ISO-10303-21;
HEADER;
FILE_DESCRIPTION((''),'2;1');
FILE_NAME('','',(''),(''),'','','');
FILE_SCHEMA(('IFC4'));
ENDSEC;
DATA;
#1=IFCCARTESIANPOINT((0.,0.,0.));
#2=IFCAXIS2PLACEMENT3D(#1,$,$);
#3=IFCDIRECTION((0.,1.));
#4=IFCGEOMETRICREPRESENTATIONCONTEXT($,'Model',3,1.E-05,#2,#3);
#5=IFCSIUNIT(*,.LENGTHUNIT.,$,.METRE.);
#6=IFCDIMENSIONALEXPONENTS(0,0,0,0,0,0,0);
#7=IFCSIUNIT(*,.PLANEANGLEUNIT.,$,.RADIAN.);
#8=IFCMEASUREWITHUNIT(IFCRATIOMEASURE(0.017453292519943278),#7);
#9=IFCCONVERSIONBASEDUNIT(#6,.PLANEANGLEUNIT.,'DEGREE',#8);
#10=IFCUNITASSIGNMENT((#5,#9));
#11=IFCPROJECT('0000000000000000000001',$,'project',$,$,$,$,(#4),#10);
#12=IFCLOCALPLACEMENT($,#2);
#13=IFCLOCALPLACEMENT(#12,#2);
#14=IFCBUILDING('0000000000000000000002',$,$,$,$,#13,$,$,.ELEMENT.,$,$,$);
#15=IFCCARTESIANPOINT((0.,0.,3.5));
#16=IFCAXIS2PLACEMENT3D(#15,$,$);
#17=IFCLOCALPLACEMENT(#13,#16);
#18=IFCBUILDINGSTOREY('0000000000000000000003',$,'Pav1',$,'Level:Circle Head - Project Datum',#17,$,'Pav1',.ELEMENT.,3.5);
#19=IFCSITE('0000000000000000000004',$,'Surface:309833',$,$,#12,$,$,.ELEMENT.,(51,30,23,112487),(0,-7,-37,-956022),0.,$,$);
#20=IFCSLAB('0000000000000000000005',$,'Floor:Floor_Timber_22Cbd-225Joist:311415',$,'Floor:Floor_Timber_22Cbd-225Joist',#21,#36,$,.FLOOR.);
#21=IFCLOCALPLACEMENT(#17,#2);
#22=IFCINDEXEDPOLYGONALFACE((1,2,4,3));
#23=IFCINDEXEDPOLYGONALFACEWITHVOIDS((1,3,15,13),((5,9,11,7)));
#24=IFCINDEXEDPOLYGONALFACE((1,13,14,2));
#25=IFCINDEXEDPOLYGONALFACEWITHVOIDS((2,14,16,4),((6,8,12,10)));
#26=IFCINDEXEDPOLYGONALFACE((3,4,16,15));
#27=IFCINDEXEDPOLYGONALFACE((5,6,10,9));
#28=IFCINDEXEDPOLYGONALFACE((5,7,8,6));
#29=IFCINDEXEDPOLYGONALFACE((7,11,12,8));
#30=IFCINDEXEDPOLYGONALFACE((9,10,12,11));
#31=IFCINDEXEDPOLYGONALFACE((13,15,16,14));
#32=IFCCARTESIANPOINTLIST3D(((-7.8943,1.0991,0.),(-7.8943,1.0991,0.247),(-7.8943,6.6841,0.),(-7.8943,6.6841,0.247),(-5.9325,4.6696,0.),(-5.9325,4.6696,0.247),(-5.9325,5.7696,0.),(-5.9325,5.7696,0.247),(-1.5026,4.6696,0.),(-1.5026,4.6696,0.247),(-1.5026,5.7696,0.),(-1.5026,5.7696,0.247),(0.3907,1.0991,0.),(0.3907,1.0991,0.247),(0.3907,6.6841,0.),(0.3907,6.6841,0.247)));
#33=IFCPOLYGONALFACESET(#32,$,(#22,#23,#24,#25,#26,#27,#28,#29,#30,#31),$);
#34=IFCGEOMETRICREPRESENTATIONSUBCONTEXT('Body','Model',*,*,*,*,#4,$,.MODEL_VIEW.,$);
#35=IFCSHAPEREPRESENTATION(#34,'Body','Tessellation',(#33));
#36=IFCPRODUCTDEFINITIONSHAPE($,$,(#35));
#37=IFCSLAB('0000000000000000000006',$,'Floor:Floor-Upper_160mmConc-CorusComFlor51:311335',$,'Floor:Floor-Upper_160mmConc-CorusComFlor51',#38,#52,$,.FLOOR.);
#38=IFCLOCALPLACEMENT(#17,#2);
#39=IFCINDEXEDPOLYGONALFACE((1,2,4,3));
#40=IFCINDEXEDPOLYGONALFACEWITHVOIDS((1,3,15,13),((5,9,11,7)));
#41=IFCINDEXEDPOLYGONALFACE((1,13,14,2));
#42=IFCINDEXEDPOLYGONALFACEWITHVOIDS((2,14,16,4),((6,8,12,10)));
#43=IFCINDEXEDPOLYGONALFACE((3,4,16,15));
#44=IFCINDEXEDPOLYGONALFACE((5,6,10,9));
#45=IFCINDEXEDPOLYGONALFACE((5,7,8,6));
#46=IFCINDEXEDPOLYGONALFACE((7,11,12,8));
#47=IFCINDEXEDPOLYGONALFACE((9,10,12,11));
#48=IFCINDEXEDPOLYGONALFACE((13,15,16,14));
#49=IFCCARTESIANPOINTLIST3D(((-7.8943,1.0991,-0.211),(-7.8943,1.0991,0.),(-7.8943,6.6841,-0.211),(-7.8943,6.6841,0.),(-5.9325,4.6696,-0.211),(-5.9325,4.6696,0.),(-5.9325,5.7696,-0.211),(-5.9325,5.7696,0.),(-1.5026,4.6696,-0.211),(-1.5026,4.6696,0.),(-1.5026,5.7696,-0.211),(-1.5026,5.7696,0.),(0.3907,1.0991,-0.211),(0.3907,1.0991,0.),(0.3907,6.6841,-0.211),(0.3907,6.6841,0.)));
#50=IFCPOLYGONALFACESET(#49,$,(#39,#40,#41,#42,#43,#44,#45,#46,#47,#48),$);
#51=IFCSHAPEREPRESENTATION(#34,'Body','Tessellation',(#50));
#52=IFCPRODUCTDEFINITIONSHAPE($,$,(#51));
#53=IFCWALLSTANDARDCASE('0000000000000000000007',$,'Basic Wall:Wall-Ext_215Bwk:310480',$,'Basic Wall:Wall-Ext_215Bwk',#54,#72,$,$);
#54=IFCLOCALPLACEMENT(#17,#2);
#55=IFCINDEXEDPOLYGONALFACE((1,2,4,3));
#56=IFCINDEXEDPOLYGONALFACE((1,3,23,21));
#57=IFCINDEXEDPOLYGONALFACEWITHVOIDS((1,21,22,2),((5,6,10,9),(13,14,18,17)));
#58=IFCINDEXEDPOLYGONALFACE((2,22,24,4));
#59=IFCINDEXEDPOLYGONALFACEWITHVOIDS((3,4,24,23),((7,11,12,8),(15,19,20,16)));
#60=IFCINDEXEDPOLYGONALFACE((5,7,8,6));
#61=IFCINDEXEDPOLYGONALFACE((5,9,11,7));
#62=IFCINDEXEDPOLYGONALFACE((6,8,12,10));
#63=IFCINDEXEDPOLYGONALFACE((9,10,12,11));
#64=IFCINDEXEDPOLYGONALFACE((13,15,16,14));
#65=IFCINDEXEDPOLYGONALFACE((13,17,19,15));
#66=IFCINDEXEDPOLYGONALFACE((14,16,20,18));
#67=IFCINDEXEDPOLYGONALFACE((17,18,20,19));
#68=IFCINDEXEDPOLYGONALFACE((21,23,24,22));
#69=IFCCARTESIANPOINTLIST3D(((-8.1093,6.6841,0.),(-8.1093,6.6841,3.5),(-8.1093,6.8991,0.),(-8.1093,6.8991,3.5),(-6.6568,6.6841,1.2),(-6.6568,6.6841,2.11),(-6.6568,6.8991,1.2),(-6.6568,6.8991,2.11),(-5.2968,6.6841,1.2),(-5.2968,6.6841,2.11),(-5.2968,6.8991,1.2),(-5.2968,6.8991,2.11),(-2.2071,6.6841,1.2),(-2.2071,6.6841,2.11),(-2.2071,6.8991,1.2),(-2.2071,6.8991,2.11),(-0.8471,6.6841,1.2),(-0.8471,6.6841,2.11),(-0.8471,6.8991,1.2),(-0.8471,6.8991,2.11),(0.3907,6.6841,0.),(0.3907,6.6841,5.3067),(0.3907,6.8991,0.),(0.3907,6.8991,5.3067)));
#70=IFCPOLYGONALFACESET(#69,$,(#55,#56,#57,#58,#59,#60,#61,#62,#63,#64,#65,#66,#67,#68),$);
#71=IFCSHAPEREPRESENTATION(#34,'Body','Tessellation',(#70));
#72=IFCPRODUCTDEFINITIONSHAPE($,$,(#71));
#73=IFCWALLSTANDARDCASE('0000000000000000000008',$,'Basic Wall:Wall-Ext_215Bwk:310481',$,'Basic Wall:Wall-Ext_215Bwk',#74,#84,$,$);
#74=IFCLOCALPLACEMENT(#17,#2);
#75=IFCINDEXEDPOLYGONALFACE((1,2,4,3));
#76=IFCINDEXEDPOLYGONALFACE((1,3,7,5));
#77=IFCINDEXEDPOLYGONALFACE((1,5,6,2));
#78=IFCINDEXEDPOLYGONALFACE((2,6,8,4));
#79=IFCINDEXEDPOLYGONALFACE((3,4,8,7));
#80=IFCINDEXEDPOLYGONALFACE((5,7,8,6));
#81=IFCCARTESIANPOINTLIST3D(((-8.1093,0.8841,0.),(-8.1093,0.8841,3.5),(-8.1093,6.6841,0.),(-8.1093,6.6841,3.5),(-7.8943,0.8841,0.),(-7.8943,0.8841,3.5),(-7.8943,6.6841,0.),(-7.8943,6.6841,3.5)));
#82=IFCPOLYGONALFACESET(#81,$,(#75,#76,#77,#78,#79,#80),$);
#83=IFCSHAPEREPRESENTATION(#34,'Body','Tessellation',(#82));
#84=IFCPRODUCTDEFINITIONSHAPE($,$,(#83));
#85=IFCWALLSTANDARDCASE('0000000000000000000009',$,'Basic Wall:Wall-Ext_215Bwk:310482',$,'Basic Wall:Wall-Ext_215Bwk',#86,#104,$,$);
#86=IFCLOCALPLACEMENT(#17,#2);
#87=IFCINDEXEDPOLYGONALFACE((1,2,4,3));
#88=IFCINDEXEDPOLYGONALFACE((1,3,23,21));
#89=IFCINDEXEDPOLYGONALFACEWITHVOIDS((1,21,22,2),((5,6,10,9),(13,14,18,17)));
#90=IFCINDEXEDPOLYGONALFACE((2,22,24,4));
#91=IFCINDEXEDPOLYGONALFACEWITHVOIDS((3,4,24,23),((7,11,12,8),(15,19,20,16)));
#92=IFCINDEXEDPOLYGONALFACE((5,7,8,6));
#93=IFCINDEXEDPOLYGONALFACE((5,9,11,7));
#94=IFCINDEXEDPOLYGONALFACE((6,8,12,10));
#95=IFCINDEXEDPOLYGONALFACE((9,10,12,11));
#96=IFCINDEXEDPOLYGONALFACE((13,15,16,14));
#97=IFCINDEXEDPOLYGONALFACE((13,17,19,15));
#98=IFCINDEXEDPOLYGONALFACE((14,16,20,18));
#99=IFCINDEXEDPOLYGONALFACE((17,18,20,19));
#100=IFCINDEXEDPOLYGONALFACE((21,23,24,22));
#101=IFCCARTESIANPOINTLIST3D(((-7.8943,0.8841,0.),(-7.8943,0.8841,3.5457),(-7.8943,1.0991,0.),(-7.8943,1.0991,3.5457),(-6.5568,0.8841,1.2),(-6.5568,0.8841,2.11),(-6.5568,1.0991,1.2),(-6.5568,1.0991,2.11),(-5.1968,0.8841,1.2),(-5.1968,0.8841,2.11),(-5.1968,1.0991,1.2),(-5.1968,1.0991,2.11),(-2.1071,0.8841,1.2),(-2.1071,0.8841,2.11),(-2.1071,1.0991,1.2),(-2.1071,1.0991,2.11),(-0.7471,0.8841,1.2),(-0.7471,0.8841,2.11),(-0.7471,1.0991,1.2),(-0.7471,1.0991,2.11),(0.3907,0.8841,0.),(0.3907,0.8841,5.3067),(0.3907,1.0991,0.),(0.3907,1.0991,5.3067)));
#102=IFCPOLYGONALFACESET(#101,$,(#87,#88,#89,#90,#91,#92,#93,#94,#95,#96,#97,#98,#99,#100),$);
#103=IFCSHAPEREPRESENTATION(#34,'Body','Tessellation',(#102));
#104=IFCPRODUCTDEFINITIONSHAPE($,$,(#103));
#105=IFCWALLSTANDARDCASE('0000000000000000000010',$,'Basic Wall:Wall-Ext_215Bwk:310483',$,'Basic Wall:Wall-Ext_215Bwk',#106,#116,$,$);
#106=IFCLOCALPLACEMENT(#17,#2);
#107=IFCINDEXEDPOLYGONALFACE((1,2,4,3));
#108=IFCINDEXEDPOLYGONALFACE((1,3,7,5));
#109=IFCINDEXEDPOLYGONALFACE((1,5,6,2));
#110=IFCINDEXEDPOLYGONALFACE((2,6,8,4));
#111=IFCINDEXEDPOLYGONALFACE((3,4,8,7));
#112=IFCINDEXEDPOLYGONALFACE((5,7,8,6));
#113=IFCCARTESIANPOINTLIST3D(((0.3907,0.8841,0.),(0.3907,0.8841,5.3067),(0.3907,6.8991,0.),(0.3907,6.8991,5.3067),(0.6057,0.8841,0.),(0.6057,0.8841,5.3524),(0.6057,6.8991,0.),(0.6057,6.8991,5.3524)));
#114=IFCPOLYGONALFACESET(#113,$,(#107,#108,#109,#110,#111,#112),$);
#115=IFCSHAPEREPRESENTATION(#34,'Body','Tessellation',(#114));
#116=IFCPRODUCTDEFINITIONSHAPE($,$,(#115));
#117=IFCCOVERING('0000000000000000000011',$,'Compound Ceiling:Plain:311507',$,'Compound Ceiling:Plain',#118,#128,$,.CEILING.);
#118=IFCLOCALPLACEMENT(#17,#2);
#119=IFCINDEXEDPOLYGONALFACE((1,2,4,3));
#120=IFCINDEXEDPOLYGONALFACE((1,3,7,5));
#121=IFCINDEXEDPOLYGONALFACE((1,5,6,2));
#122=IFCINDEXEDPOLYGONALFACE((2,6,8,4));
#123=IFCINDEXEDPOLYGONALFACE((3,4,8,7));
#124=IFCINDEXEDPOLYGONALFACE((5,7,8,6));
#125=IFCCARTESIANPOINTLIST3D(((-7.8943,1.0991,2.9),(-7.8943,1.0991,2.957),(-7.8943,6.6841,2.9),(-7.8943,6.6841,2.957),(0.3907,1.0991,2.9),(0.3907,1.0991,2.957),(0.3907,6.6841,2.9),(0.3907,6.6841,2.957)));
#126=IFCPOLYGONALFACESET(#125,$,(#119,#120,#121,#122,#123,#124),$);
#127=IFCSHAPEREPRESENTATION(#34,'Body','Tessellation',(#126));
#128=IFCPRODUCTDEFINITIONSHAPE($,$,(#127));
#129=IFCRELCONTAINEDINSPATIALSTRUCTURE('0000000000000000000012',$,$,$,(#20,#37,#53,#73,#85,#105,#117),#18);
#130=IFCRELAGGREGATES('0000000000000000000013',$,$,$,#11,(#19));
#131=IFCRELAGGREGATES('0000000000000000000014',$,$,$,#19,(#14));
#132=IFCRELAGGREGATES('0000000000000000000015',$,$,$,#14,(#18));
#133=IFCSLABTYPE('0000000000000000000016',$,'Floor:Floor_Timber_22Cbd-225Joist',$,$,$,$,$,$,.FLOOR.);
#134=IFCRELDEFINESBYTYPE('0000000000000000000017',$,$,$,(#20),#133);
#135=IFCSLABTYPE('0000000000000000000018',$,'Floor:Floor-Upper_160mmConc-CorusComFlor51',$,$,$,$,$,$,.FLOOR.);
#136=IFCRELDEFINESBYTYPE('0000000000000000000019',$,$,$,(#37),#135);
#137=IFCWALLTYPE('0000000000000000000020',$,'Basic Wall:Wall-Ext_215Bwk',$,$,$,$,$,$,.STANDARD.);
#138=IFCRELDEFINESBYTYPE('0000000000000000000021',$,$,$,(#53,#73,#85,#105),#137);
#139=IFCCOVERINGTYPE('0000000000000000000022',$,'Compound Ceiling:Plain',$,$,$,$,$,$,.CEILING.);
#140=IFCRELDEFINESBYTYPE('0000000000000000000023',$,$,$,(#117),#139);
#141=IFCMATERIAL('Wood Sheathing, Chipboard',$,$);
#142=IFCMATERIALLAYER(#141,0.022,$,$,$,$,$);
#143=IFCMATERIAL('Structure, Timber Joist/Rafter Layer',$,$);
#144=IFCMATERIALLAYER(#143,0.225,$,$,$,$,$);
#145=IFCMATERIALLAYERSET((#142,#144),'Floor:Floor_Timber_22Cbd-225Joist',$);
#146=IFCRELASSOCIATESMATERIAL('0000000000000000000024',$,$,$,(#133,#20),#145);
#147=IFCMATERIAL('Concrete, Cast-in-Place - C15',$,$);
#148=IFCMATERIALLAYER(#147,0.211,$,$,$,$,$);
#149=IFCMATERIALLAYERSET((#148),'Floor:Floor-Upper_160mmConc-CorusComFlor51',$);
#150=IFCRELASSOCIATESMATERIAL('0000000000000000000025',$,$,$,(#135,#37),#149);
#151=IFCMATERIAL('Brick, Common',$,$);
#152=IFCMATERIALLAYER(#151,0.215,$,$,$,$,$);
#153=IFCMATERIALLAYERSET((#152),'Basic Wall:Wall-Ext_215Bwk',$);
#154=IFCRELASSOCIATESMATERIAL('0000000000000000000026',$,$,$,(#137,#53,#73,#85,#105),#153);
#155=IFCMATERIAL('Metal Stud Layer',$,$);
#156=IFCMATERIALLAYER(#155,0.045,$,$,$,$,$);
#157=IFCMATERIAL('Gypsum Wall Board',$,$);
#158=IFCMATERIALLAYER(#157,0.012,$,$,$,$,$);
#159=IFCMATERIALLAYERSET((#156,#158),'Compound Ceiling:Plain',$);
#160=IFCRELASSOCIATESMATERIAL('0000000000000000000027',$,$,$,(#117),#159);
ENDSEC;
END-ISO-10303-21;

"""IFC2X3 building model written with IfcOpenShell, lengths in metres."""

from ifc_helpers import new_model, entity, si_unit, converted_unit, direction, frame, frame_2d, origin, place, context, subcontext, project, spatial, polyline, rectangle, extrude, clip, bounded_halfspace, material, layer, layer_set, layer_usage, type_object, element, save


model = new_model("IFC2X3")

# Units and contexts
model_context = context("Model", 3, precision=1e-05, world=origin(), true_north=direction((0.0, 1.0)))
body_context = subcontext(model_context, "Body", "Model", "MODEL_VIEW")
ifc_project = project(units=[si_unit("LENGTHUNIT", "METRE"), converted_unit("PLANEANGLEUNIT", "DEGREE", entity("IfcRatioMeasure", 0.017453292519943278), si_unit("PLANEANGLEUNIT", "RADIAN"), dimensions=[0, 0, 0, 0, 0, 0, 0])], contexts=[model_context])

# Site, building, storey
site_placement = place(None, origin())
site = spatial("IfcSite", under=ifc_project, at=site_placement, Name="Surface:309833", CompositionType="ELEMENT", RefLatitude=(51, 30, 23, 112487), RefLongitude=(0, -7, -37, -956022), RefElevation=0.0)
building_placement = place(site_placement, origin())
building = spatial("IfcBuilding", under=site, at=building_placement, CompositionType="ELEMENT")
storey_placement = place(building_placement, frame((0.0, 0.0, 3.5)))
storey = spatial("IfcBuildingStorey", under=building, at=storey_placement, Name="Pav1", ObjectType="Level:Circle Head - Project Datum", LongName="Pav1", CompositionType="ELEMENT", Elevation=3.5)

# Slabs, openings
ifc_material_1 = material(Name="Wood Sheathing, Chipboard")
ifc_layer_1 = layer(ifc_material_1, 0.022)
ifc_material_2 = material(Name="Structure, Timber Joist/Rafter Layer")
ifc_layer_2 = layer(ifc_material_2, 0.225)
ifc_layer_set_1 = layer_set([ifc_layer_1, ifc_layer_2], Name="Floor:Floor_Timber_22Cbd-225Joist")
ifc_layer_usage_1 = layer_usage(ifc_layer_set_1, "AXIS3", "POSITIVE", 0.0)
slab_type_1 = type_object("IfcSlabType", Name="Floor:Floor_Timber_22Cbd-225Joist", PredefinedType="FLOOR", material=ifc_layer_set_1)
slab_1_placement = place(storey_placement, frame((-7.8943, 1.0991, 0.0)))
slab_1 = element("IfcSlab", 1, at=slab_1_placement, inside=storey, type_object=slab_type_1, material=ifc_layer_usage_1, Name="Floor:Floor_Timber_22Cbd-225Joist:311415", ObjectType="Floor:Floor_Timber_22Cbd-225Joist", PredefinedType="FLOOR", context=body_context, shape_type="SweptSolid", body=[
    extrude(rectangle(XDim=5.585, YDim=8.285, at=frame_2d((0.0, 0.0), x_axis=(0.0, -1.0))), frame((4.1425, 2.7925, 0.247), z_axis=(0.0, 0.0, -1.0), x_axis=(-1.0, 0.0, 0.0)), (0.0, 0.0, 1.0), 0.247),
])
opening_1_placement = place(slab_1_placement, origin())
element("IfcOpeningElement", 2, at=opening_1_placement, cuts=slab_1, ObjectType="Opening", context=body_context, shape_type="SweptSolid", body=[
    extrude(rectangle(XDim=4.4299, YDim=1.1, at=frame_2d((0.0, 0.0), x_axis=(1.0, 0.0))), frame((4.1768, 4.1206, 0.247), z_axis=(0.0, 0.0, -1.0), x_axis=(1.0, 0.0, 0.0)), (0.0, 0.0, 1.0), 0.247),
])
ifc_material_3 = material(Name="Concrete, Cast-in-Place - C15")
ifc_layer_3 = layer(ifc_material_3, 0.211)
ifc_layer_set_2 = layer_set([ifc_layer_3], Name="Floor:Floor-Upper_160mmConc-CorusComFlor51")
ifc_layer_usage_2 = layer_usage(ifc_layer_set_2, "AXIS3", "POSITIVE", 0.0)
slab_type_2 = type_object("IfcSlabType", Name="Floor:Floor-Upper_160mmConc-CorusComFlor51", PredefinedType="FLOOR", material=ifc_layer_set_2)
slab_2_placement = place(storey_placement, frame((-7.8943, 1.0991, -0.211)))
slab_2 = element("IfcSlab", 3, at=slab_2_placement, inside=storey, type_object=slab_type_2, material=ifc_layer_usage_2, Name="Floor:Floor-Upper_160mmConc-CorusComFlor51:311335", ObjectType="Floor:Floor-Upper_160mmConc-CorusComFlor51", PredefinedType="FLOOR", context=body_context, shape_type="SweptSolid", body=[
    extrude(rectangle(XDim=5.585, YDim=8.285, at=frame_2d((0.0, 0.0), x_axis=(0.0, -1.0))), frame((4.1425, 2.7925, 0.211), z_axis=(0.0, 0.0, -1.0), x_axis=(-1.0, 0.0, 0.0)), (0.0, 0.0, 1.0), 0.211),
])
opening_2_placement = place(slab_2_placement, origin())
element("IfcOpeningElement", 4, at=opening_2_placement, cuts=slab_2, ObjectType="Opening", context=body_context, shape_type="SweptSolid", body=[
    extrude(rectangle(XDim=1.1, YDim=4.4299, at=frame_2d((0.0, 0.0), x_axis=(1.0, 0.0))), frame((4.1768, 4.1206, 0.211), z_axis=(0.0, 0.0, -1.0), x_axis=(0.0, -1.0, 0.0)), (0.0, 0.0, 1.0), 0.211),
])

# Wall, openings
ifc_material_4 = material(Name="Brick, Common")
ifc_layer_4 = layer(ifc_material_4, 0.215)
ifc_layer_set_3 = layer_set([ifc_layer_4], Name="Basic Wall:Wall-Ext_215Bwk")
ifc_layer_usage_3 = layer_usage(ifc_layer_set_3, "AXIS2", "NEGATIVE", 0.1075)
wall_type = type_object("IfcWallType", Name="Basic Wall:Wall-Ext_215Bwk", PredefinedType="STANDARD", material=ifc_layer_set_3)
wall_1_placement = place(storey_placement, frame((-8.1093, 6.7916, 0.0)))
wall_1 = element("IfcWallStandardCase", 5, at=wall_1_placement, inside=storey, type_object=wall_type, material=ifc_layer_usage_3, Name="Basic Wall:Wall-Ext_215Bwk:310480", ObjectType="Basic Wall:Wall-Ext_215Bwk", context=body_context, shape_type="Clipping", body=[
    clip(extrude(rectangle(XDim=8.5, YDim=0.215, at=frame_2d((4.25, 0.0), x_axis=(-1.0, 0.0))), origin(), (0.0, 0.0, 1.0), 5.3067), bounded_halfspace(frame((0.0, -0.1075, 3.5), z_axis=(-0.207912, 0.0, 0.978148), x_axis=(0.0, -1.0, 0.0)), False, frame((0.0, -0.1075, 3.5)), polyline([(0.0, 0.0), (8.5, 0.0), (8.5, 0.215), (0.0, 0.215), (0.0, 0.0)]))),
])
opening_3_placement = place(wall_1_placement, frame((2.8125, 0.1075, 1.2)))
element("IfcOpeningElement", 6, at=opening_3_placement, cuts=wall_1, ObjectType="Opening", context=body_context, shape_type="SweptSolid", body=[
    extrude(rectangle(XDim=0.91, YDim=1.36, at=frame_2d((0.455, 0.68), x_axis=(-1.0, 0.0))), frame((0.0, 0.0, 0.0), z_axis=(0.0, -1.0, 0.0), x_axis=(0.0, 0.0, 1.0)), (0.0, 0.0, 1.0), 0.215),
])
opening_4_placement = place(wall_1_placement, frame((7.2622, 0.1075, 1.2)))
element("IfcOpeningElement", 7, at=opening_4_placement, cuts=wall_1, ObjectType="Opening", context=body_context, shape_type="SweptSolid", body=[
    extrude(rectangle(XDim=0.91, YDim=1.36, at=frame_2d((0.455, 0.68), x_axis=(-1.0, 0.0))), frame((0.0, 0.0, 0.0), z_axis=(0.0, -1.0, 0.0), x_axis=(0.0, 0.0, 1.0)), (0.0, 0.0, 1.0), 0.215),
])

# Wall
wall_2_placement = place(storey_placement, frame((-8.0018, 0.8841, 0.0), z_axis=(0.0, 0.0, 1.0), x_axis=(0.0, 1.0, 0.0)))
element("IfcWallStandardCase", 8, at=wall_2_placement, inside=storey, type_object=wall_type, material=ifc_layer_usage_3, Name="Basic Wall:Wall-Ext_215Bwk:310481", ObjectType="Basic Wall:Wall-Ext_215Bwk", context=body_context, shape_type="SweptSolid", body=[
    extrude(rectangle(XDim=5.8, YDim=0.215, at=frame_2d((2.9, 0.0), x_axis=(-1.0, 0.0))), origin(), (0.0, 0.0, 1.0), 3.5),
])

# Wall, openings
wall_3_placement = place(storey_placement, frame((0.3907, 0.9916, 0.0), z_axis=(0.0, 0.0, 1.0), x_axis=(-1.0, 0.0, 0.0)))
wall_3 = element("IfcWallStandardCase", 9, at=wall_3_placement, inside=storey, type_object=wall_type, material=ifc_layer_usage_3, Name="Basic Wall:Wall-Ext_215Bwk:310482", ObjectType="Basic Wall:Wall-Ext_215Bwk", context=body_context, shape_type="Clipping", body=[
    clip(extrude(rectangle(XDim=8.285, YDim=0.215, at=frame_2d((4.1425, 0.0), x_axis=(-1.0, 0.0))), origin(), (0.0, 0.0, 1.0), 5.3067), bounded_halfspace(frame((0.0, -0.1075, 5.3067), z_axis=(0.207912, 0.0, 0.978148), x_axis=(0.0, 1.0, 0.0)), False, frame((0.0, -0.1075, 5.3067)), polyline([(0.0, 0.0), (8.285, 0.0), (8.285, 0.215), (0.0, 0.215), (0.0, 0.0)]))),
])
opening_5_placement = place(wall_3_placement, frame((5.5875, -0.1075, 1.2)))
element("IfcOpeningElement", 10, at=opening_5_placement, cuts=wall_3, ObjectType="Opening", context=body_context, shape_type="SweptSolid", body=[
    extrude(rectangle(XDim=0.91, YDim=1.36, at=frame_2d((0.455, 0.68), x_axis=(-1.0, 0.0))), frame((0.0, 0.0, 0.0), z_axis=(0.0, 1.0, 0.0), x_axis=(0.0, 0.0, 1.0)), (0.0, 0.0, 1.0), 0.215),
])
opening_6_placement = place(wall_3_placement, frame((2.4978, 0.1075, 1.2)))
element("IfcOpeningElement", 11, at=opening_6_placement, cuts=wall_3, ObjectType="Opening", context=body_context, shape_type="SweptSolid", body=[
    extrude(rectangle(XDim=0.91, YDim=1.36, at=frame_2d((0.455, 0.68), x_axis=(-1.0, 0.0))), frame((0.0, 0.0, 0.0), z_axis=(0.0, -1.0, 0.0), x_axis=(0.0, 0.0, 1.0)), (0.0, 0.0, 1.0), 0.215),
])

# Wall
wall_4_placement = place(storey_placement, frame((0.4982, 6.8991, 0.0), z_axis=(0.0, 0.0, 1.0), x_axis=(0.0, -1.0, 0.0)))
element("IfcWallStandardCase", 12, at=wall_4_placement, inside=storey, type_object=wall_type, material=ifc_layer_usage_3, Name="Basic Wall:Wall-Ext_215Bwk:310483", ObjectType="Basic Wall:Wall-Ext_215Bwk", context=body_context, shape_type="Clipping", body=[
    clip(extrude(rectangle(XDim=6.015, YDim=0.215, at=frame_2d((3.0075, 0.0), x_axis=(-1.0, 0.0))), origin(), (0.0, 0.0, 1.0), 5.3524), bounded_halfspace(frame((0.0, -0.1075, 5.3067), z_axis=(0.0, -0.207912, 0.978148), x_axis=(1.0, 0.0, 0.0)), False, frame((0.0, -0.1075, 5.3067)), polyline([(0.0, 0.0), (0.215, 0.0), (5.8, 0.0), (6.015, 0.0), (6.015, 0.215), (0.0, 0.215), (0.0, 0.0)]))),
])

# Covering
ifc_material_5 = material(Name="Metal Stud Layer")
ifc_layer_5 = layer(ifc_material_5, 0.045)
ifc_material_6 = material(Name="Gypsum Wall Board")
ifc_layer_6 = layer(ifc_material_6, 0.012)
ifc_layer_set_4 = layer_set([ifc_layer_5, ifc_layer_6], Name="Compound Ceiling:Plain")
ifc_layer_usage_4 = layer_usage(ifc_layer_set_4, "AXIS3", "POSITIVE", 0.0)
covering_type = type_object("IfcCoveringType", Name="Compound Ceiling:Plain", PredefinedType="CEILING")
covering_placement = place(storey_placement, origin())
element("IfcCovering", 13, at=covering_placement, inside=storey, type_object=covering_type, material=ifc_layer_usage_4, Name="Compound Ceiling:Plain:311507", ObjectType="Compound Ceiling:Plain", PredefinedType="CEILING", context=body_context, shape_type="SweptSolid", body=[
    extrude(rectangle(XDim=5.585, YDim=8.285, at=frame_2d((0.0, 0.0), x_axis=(1.0, 0.0))), frame((-3.7518, 3.8916, 2.9), z_axis=(0.0, 0.0, 1.0), x_axis=(0.0, -1.0, 0.0)), (0.0, 0.0, 1.0), 0.057),
])

save(model, "model.ifc")
